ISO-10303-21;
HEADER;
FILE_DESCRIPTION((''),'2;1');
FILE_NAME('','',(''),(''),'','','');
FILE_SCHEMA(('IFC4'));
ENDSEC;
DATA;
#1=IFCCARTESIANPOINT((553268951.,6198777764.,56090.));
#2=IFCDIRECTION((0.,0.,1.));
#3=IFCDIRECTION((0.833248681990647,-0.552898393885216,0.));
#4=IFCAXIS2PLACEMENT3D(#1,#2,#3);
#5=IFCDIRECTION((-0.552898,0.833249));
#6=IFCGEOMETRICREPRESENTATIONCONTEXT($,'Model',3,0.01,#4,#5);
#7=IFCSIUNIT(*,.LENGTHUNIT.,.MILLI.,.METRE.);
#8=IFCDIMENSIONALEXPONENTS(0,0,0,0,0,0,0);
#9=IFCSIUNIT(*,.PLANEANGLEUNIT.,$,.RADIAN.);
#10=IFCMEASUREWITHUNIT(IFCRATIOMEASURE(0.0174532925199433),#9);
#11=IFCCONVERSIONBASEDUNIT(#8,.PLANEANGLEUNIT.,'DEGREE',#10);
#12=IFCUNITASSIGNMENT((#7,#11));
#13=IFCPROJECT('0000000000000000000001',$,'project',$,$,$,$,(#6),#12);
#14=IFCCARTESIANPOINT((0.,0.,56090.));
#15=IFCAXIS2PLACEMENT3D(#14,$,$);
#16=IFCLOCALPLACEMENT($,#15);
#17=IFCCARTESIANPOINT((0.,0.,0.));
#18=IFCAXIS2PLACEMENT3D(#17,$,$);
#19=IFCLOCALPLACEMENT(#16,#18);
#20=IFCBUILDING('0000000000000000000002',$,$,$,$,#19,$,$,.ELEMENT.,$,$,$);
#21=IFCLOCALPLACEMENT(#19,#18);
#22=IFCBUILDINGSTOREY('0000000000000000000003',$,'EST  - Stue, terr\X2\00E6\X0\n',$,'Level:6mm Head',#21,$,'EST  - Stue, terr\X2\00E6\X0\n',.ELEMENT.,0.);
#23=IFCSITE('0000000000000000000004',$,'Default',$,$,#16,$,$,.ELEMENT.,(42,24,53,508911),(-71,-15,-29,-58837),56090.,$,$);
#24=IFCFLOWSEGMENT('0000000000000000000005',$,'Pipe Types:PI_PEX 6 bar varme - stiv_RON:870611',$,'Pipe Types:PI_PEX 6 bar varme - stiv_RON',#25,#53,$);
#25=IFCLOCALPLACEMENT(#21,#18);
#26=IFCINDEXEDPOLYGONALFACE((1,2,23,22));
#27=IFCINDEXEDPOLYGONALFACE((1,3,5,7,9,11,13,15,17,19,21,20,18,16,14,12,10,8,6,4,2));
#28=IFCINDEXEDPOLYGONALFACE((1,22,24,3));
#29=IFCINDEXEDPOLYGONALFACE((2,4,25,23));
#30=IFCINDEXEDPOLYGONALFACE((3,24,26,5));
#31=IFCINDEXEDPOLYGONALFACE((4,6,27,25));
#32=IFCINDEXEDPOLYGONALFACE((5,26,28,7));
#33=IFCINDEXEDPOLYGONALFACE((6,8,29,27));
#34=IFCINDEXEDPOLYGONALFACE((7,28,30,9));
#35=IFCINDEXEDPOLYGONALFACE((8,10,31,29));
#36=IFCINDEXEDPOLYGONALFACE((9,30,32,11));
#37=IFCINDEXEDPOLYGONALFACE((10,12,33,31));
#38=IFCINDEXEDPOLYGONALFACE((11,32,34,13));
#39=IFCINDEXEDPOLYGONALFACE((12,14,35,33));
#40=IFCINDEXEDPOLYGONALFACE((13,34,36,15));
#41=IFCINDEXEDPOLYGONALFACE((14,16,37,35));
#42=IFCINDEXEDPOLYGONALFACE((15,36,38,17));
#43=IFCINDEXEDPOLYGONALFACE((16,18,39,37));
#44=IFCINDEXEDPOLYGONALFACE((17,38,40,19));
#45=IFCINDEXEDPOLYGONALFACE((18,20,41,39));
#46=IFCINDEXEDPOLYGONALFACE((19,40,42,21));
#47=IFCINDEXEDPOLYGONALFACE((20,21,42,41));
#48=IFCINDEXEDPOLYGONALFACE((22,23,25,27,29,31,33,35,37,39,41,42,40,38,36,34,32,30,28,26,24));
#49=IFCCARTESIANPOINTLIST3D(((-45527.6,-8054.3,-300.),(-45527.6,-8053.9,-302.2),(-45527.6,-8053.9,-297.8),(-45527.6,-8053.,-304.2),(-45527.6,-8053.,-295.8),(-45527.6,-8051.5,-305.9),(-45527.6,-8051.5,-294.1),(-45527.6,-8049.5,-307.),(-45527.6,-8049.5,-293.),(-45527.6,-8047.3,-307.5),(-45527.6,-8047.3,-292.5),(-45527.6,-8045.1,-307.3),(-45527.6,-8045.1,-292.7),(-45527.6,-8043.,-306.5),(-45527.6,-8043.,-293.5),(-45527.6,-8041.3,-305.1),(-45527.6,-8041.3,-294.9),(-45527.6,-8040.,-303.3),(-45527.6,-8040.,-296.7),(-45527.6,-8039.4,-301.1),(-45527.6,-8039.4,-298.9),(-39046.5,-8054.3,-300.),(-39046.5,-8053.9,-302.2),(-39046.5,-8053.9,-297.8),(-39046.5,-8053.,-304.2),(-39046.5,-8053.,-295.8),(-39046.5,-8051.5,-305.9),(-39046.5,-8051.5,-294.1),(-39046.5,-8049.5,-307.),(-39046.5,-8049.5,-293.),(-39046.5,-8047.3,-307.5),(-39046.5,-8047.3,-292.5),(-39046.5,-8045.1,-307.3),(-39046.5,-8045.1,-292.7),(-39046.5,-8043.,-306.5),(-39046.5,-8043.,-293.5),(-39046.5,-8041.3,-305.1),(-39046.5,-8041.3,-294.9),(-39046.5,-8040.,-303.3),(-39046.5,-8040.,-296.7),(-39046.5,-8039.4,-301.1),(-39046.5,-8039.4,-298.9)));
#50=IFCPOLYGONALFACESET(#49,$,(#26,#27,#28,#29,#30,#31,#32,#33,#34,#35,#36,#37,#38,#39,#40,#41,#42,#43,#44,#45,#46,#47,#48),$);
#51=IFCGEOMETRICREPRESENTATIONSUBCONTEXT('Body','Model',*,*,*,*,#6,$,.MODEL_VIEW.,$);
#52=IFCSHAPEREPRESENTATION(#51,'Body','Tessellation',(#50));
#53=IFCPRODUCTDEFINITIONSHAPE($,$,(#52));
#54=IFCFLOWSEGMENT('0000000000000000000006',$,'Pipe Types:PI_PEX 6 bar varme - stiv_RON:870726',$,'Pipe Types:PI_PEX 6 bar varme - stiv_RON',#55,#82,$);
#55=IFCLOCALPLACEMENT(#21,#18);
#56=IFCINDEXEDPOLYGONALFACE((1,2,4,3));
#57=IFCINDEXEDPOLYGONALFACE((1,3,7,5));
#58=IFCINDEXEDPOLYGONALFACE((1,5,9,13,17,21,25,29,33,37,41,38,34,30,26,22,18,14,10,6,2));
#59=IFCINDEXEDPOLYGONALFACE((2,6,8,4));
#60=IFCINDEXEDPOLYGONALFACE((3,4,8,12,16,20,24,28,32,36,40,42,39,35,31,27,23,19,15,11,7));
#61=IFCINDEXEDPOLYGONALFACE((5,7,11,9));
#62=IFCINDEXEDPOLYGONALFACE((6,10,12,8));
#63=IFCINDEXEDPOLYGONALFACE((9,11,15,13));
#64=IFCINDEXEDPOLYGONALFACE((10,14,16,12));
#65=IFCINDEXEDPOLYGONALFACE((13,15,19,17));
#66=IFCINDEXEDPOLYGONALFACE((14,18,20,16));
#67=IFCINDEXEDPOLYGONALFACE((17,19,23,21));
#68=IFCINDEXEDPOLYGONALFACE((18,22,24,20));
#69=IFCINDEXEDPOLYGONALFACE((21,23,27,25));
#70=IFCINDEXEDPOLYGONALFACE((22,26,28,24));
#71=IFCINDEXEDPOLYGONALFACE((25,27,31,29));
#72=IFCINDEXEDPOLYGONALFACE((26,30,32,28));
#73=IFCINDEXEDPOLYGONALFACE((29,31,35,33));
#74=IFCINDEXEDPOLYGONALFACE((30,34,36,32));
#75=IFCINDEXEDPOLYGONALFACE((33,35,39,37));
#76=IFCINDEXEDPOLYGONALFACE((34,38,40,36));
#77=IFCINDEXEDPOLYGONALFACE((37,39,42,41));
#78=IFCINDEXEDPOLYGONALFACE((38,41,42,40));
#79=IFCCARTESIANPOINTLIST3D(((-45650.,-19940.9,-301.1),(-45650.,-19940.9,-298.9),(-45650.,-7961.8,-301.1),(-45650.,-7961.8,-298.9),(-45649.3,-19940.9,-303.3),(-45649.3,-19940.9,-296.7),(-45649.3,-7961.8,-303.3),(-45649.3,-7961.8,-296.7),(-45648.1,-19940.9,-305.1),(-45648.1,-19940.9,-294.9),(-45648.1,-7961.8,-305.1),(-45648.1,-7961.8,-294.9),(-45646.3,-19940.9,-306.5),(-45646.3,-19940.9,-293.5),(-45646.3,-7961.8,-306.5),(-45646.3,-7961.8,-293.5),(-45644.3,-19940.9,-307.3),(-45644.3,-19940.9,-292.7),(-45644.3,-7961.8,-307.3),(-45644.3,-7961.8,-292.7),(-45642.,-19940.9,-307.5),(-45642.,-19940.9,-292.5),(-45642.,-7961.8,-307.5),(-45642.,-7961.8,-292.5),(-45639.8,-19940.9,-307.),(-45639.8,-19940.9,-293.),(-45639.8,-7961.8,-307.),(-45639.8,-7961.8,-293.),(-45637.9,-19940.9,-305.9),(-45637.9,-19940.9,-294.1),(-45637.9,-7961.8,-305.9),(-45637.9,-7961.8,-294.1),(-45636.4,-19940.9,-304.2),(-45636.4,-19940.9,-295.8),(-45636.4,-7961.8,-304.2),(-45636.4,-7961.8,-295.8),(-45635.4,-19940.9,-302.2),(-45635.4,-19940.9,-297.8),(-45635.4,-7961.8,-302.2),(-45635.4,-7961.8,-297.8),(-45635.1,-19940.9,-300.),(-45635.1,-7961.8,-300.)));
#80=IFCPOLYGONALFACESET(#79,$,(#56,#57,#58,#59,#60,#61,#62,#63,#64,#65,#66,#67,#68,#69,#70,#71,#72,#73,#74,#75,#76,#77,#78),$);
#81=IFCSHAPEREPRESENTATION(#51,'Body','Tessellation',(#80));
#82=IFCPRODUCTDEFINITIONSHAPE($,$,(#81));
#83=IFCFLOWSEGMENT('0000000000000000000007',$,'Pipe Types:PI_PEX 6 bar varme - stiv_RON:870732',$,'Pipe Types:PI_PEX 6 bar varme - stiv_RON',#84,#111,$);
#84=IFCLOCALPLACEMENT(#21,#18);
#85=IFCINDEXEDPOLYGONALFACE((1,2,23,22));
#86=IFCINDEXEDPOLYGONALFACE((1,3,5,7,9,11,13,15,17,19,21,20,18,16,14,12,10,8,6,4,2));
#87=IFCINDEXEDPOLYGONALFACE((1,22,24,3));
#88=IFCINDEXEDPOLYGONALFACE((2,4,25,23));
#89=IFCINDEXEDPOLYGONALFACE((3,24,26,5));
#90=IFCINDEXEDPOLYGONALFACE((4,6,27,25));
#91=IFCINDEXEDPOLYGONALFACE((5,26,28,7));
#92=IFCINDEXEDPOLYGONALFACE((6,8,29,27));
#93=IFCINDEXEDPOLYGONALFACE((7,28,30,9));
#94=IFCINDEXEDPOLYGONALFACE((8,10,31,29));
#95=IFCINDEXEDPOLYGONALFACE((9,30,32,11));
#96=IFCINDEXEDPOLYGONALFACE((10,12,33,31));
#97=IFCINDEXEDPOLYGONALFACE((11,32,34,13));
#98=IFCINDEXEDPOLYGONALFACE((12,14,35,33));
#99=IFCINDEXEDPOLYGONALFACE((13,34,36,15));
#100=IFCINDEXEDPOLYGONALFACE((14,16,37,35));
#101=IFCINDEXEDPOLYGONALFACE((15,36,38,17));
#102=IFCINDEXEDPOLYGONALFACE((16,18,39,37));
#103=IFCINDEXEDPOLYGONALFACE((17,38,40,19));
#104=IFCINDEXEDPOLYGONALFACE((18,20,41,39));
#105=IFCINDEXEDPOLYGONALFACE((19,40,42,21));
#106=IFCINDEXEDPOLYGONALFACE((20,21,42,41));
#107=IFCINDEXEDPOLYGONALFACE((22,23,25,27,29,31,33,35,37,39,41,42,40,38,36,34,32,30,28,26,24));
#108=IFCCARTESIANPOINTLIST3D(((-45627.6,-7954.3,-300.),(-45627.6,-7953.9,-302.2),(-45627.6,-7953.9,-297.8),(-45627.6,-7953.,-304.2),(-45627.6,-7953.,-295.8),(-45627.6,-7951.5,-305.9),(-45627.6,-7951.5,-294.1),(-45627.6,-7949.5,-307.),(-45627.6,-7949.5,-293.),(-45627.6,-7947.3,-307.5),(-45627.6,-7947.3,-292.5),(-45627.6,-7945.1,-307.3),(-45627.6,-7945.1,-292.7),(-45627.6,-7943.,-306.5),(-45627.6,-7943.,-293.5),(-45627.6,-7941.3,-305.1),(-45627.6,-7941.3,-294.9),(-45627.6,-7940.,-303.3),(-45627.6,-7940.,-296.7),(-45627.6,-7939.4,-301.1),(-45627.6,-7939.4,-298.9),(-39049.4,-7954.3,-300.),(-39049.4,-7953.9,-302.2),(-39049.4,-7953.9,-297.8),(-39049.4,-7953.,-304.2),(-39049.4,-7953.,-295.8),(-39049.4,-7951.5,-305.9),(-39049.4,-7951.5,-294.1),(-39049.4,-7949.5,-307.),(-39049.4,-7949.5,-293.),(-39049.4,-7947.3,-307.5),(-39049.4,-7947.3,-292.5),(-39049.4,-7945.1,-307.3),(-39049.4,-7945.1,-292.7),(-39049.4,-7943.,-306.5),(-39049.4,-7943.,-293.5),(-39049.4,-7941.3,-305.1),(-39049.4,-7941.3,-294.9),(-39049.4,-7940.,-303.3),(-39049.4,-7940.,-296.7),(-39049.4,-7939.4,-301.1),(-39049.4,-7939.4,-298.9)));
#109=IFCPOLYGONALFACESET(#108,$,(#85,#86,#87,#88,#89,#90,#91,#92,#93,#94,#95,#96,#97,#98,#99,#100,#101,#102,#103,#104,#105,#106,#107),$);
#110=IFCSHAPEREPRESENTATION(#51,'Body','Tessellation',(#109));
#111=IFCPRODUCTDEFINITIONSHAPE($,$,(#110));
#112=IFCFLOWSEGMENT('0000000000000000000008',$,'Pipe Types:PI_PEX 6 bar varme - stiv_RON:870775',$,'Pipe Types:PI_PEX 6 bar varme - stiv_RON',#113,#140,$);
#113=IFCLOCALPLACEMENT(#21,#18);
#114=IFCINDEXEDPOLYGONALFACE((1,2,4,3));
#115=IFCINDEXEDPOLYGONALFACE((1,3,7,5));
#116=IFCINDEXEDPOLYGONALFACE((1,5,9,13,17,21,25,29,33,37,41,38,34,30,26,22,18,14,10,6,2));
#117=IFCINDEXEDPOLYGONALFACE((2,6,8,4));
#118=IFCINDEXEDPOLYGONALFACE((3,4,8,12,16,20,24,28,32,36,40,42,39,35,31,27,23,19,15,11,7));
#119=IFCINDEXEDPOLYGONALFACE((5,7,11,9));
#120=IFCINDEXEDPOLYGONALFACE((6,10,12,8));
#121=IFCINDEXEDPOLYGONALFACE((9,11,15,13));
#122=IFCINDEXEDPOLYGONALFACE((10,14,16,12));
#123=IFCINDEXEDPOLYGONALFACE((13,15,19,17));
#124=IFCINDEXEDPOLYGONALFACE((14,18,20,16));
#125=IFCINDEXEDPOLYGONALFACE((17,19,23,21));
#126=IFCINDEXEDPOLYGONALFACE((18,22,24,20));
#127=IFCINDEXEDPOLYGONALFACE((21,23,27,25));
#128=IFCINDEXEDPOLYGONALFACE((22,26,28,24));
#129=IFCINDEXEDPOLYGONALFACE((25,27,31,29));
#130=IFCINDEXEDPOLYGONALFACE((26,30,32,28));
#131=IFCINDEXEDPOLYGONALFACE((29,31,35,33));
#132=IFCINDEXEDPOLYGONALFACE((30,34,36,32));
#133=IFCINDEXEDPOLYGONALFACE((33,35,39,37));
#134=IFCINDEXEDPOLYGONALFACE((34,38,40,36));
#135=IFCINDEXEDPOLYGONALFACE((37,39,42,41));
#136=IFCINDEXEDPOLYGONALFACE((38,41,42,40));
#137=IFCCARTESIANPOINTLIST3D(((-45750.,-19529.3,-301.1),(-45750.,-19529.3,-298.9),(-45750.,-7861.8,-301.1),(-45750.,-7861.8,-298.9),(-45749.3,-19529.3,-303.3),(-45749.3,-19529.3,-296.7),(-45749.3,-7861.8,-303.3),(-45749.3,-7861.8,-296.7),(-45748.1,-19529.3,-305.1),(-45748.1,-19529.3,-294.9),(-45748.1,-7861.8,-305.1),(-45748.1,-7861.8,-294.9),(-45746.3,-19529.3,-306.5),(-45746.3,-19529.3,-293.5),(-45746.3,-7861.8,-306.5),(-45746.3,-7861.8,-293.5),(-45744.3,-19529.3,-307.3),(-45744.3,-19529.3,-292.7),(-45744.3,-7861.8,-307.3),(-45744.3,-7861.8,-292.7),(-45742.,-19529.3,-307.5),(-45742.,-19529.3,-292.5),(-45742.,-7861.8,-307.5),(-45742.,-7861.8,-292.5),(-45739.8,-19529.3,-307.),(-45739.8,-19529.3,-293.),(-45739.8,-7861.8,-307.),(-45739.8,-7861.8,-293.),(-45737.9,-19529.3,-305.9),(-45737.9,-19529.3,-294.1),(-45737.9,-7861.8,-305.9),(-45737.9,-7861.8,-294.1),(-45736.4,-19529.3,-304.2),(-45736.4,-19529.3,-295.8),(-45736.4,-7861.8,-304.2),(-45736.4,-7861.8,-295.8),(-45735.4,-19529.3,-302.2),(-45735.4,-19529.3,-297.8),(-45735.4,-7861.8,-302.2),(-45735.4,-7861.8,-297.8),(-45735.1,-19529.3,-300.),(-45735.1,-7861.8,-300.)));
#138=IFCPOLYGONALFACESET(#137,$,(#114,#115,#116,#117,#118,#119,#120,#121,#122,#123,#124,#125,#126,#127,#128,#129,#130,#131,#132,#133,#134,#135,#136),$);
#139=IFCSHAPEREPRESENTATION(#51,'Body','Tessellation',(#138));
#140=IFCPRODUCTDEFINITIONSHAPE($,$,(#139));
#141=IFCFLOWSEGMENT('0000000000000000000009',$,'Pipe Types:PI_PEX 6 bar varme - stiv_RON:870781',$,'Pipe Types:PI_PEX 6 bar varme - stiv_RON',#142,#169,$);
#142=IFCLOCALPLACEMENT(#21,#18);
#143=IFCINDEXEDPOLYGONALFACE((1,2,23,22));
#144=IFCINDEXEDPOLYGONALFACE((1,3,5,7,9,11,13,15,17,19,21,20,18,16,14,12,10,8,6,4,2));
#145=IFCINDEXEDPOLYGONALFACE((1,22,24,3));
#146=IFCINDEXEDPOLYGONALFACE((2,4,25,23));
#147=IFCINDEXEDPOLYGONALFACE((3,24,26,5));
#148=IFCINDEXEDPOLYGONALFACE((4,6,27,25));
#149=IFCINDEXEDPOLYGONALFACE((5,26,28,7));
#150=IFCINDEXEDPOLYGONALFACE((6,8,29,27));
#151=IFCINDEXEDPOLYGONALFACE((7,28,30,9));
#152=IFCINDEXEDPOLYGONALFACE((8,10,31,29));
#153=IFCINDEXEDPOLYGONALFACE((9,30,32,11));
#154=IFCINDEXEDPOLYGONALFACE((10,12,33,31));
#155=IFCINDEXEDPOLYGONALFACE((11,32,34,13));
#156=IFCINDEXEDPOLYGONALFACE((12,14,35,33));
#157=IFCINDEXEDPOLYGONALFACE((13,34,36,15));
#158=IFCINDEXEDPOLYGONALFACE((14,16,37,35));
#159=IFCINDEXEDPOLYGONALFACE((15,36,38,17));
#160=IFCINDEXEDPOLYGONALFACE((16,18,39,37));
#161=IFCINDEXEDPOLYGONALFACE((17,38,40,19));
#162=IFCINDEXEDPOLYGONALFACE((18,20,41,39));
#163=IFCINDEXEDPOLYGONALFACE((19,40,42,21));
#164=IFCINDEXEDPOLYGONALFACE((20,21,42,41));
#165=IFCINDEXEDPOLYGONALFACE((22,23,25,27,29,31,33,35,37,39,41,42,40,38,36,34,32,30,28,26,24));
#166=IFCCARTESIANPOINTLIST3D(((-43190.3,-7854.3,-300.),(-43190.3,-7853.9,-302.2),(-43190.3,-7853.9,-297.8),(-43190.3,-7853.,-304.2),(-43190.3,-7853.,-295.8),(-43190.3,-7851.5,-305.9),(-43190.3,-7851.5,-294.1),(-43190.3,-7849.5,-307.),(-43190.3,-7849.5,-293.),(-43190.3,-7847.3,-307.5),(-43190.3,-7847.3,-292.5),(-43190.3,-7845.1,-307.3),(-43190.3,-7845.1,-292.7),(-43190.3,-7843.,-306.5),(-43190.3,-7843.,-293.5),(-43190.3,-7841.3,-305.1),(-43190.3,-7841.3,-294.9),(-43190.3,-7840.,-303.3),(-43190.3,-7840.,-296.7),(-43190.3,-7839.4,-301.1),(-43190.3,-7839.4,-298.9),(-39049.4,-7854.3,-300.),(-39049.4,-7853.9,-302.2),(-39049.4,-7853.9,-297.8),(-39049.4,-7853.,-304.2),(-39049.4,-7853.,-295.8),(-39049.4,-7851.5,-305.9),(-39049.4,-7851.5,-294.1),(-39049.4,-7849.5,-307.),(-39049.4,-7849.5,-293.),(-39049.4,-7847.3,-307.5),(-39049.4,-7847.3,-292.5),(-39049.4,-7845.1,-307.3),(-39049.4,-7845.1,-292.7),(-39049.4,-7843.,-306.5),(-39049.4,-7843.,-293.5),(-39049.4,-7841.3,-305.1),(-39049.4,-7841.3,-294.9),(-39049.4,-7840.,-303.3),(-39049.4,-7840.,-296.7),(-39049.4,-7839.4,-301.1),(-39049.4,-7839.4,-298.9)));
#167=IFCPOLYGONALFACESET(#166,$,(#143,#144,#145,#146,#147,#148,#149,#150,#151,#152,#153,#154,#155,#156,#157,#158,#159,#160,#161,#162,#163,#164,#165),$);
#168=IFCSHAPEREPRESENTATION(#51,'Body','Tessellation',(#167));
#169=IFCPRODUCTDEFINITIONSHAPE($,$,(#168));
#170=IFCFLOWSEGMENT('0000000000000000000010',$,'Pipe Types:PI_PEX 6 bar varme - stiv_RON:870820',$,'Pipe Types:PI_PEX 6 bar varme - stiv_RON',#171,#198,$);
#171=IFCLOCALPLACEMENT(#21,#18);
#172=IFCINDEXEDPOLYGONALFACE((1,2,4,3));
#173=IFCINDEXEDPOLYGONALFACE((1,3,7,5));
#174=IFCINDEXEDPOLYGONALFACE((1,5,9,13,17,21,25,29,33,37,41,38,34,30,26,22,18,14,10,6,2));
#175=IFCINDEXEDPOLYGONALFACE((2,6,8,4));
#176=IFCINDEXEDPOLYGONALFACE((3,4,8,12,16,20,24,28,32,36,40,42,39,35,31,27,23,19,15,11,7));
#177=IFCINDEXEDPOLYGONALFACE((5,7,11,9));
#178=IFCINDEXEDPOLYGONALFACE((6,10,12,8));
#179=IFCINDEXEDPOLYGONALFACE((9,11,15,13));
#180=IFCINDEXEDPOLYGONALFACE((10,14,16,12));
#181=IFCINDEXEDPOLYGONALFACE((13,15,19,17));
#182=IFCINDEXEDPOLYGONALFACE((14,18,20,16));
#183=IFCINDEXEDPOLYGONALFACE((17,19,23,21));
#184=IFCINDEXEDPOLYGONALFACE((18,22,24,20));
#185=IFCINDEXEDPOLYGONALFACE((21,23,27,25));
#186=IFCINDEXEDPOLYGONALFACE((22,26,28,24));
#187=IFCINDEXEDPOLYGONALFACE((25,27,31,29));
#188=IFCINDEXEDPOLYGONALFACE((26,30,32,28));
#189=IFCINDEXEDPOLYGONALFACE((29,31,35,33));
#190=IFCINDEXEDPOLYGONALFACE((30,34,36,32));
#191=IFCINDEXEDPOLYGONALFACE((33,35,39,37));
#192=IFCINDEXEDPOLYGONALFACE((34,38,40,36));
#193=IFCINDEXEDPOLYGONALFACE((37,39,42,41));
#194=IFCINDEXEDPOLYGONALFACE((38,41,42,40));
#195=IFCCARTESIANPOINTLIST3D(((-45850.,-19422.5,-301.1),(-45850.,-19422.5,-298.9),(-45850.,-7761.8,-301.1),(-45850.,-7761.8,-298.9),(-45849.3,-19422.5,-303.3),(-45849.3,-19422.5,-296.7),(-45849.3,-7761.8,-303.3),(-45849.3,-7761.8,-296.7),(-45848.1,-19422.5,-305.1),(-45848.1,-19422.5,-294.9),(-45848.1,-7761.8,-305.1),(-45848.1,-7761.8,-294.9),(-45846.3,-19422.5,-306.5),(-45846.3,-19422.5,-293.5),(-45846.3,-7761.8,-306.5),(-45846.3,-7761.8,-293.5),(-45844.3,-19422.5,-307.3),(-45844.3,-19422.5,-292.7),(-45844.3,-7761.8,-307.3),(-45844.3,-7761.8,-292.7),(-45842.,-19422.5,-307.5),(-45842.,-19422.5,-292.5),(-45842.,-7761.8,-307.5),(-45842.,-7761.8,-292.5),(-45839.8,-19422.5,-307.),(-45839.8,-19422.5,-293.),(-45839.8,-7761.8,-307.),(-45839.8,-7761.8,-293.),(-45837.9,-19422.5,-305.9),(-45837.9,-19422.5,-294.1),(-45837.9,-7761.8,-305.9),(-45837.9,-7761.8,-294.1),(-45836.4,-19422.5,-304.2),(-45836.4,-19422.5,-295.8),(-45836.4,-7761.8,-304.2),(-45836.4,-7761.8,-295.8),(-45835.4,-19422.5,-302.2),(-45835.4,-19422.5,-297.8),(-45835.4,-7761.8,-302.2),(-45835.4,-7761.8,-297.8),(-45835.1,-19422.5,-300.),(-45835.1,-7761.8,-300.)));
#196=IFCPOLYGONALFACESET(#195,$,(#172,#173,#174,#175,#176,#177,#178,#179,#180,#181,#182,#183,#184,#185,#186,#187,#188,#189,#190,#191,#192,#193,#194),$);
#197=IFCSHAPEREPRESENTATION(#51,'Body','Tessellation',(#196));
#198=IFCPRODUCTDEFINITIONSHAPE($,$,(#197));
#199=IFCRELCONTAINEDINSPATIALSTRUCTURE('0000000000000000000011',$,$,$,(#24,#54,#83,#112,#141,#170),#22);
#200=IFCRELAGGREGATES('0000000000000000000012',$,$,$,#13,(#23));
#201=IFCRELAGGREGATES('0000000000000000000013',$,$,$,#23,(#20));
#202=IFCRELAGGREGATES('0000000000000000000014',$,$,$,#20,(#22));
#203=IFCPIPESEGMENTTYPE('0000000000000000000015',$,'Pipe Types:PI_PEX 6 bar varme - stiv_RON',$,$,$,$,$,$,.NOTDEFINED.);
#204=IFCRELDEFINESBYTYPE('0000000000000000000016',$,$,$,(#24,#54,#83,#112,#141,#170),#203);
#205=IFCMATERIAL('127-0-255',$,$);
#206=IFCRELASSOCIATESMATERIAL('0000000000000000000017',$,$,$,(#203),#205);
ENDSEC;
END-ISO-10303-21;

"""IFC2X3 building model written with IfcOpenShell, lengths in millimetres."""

from ifc_helpers import new_model, entity, si_unit, converted_unit, direction, frame, origin, origin_2d_with_axis, place, context, subcontext, project, spatial, circle, extrude, material, type_object, element, save


model = new_model("IFC2X3")

# Units and contexts
model_context = context("Model", 3, precision=0.01, world=frame((553268951.0, 6198777764.0, 56090.0), z_axis=(0.0, 0.0, 1.0), x_axis=(0.833248681990647, -0.552898393885216, 0.0)), true_north=direction((-0.552898, 0.833249)))
body_context = subcontext(model_context, "Body", "Model", "MODEL_VIEW")
ifc_project = project(units=[si_unit("LENGTHUNIT", "METRE", prefix="MILLI"), converted_unit("PLANEANGLEUNIT", "DEGREE", entity("IfcRatioMeasure", 0.0174532925199433), si_unit("PLANEANGLEUNIT", "RADIAN"), dimensions=[0, 0, 0, 0, 0, 0, 0])], contexts=[model_context])

# Site, building, storey
site_placement = place(None, frame((0.0, 0.0, 56090.0)))
site = spatial("IfcSite", under=ifc_project, at=site_placement, Name="Default", CompositionType="ELEMENT", RefLatitude=(42, 24, 53, 508911), RefLongitude=(-71, -15, -29, -58837), RefElevation=56090.0)
building_placement = place(site_placement, origin())
building = spatial("IfcBuilding", under=site, at=building_placement, CompositionType="ELEMENT")
storey_placement = place(building_placement, frame((0.0, 0.0, 0.0)))
storey = spatial("IfcBuildingStorey", under=building, at=storey_placement, Name="EST  - Stue, terræn", ObjectType="Level:6mm Head", LongName="EST  - Stue, terræn", CompositionType="ELEMENT", Elevation=0.0)

# Flow segments
ifc_material = material(Name="127-0-255")
pipe_segment_type = type_object("IfcPipeSegmentType", Name="Pipe Types:PI_PEX 6 bar varme - stiv_RON", PredefinedType="NOTDEFINED", material=ifc_material)
flow_segment_1_placement = place(storey_placement, origin())
element("IfcFlowSegment", 1, at=flow_segment_1_placement, inside=storey, type_object=pipe_segment_type, Name="Pipe Types:PI_PEX 6 bar varme - stiv_RON:870611", ObjectType="Pipe Types:PI_PEX 6 bar varme - stiv_RON", context=body_context, shape_type="SweptSolid", body=[
    extrude(circle(Radius=7.5, at=origin_2d_with_axis()), frame((-45527.6, -8046.8, -300.0), z_axis=(1.0, 0.0, 0.0), x_axis=(0.0, -1.0, 0.0)), (0.0, 0.0, 1.0), 6481.1),
])
flow_segment_2_placement = place(storey_placement, origin())
element("IfcFlowSegment", 2, at=flow_segment_2_placement, inside=storey, type_object=pipe_segment_type, Name="Pipe Types:PI_PEX 6 bar varme - stiv_RON:870726", ObjectType="Pipe Types:PI_PEX 6 bar varme - stiv_RON", context=body_context, shape_type="SweptSolid", body=[
    extrude(circle(Radius=7.5, at=origin_2d_with_axis()), frame((-45642.6, -19940.9, -300.0), z_axis=(0.0, 1.0, 0.0), x_axis=(1.0, 0.0, 0.0)), (0.0, 0.0, 1.0), 11979.1),
])
flow_segment_3_placement = place(storey_placement, origin())
element("IfcFlowSegment", 3, at=flow_segment_3_placement, inside=storey, type_object=pipe_segment_type, Name="Pipe Types:PI_PEX 6 bar varme - stiv_RON:870732", ObjectType="Pipe Types:PI_PEX 6 bar varme - stiv_RON", context=body_context, shape_type="SweptSolid", body=[
    extrude(circle(Radius=7.5, at=origin_2d_with_axis()), frame((-45627.6, -7946.8, -300.0), z_axis=(1.0, 0.0, 0.0), x_axis=(0.0, -1.0, 0.0)), (0.0, 0.0, 1.0), 6578.2),
])
flow_segment_4_placement = place(storey_placement, origin())
element("IfcFlowSegment", 4, at=flow_segment_4_placement, inside=storey, type_object=pipe_segment_type, Name="Pipe Types:PI_PEX 6 bar varme - stiv_RON:870775", ObjectType="Pipe Types:PI_PEX 6 bar varme - stiv_RON", context=body_context, shape_type="SweptSolid", body=[
    extrude(circle(Radius=7.5, at=origin_2d_with_axis()), frame((-45742.6, -19529.3, -300.0), z_axis=(0.0, 1.0, 0.0), x_axis=(1.0, 0.0, 0.0)), (0.0, 0.0, 1.0), 11667.5),
])
flow_segment_5_placement = place(storey_placement, origin())
element("IfcFlowSegment", 5, at=flow_segment_5_placement, inside=storey, type_object=pipe_segment_type, Name="Pipe Types:PI_PEX 6 bar varme - stiv_RON:870781", ObjectType="Pipe Types:PI_PEX 6 bar varme - stiv_RON", context=body_context, shape_type="SweptSolid", body=[
    extrude(circle(Radius=7.5, at=origin_2d_with_axis()), frame((-43190.3, -7846.8, -300.0), z_axis=(1.0, 0.0, 0.0), x_axis=(0.0, -1.0, 0.0)), (0.0, 0.0, 1.0), 4140.9),
])
flow_segment_6_placement = place(storey_placement, origin())
element("IfcFlowSegment", 6, at=flow_segment_6_placement, inside=storey, type_object=pipe_segment_type, Name="Pipe Types:PI_PEX 6 bar varme - stiv_RON:870820", ObjectType="Pipe Types:PI_PEX 6 bar varme - stiv_RON", context=body_context, shape_type="SweptSolid", body=[
    extrude(circle(Radius=7.5, at=origin_2d_with_axis()), frame((-45842.6, -19422.5, -300.0), z_axis=(0.0, 1.0, 0.0), x_axis=(1.0, 0.0, 0.0)), (0.0, 0.0, 1.0), 11660.7),
])

save(model, "model.ifc")
